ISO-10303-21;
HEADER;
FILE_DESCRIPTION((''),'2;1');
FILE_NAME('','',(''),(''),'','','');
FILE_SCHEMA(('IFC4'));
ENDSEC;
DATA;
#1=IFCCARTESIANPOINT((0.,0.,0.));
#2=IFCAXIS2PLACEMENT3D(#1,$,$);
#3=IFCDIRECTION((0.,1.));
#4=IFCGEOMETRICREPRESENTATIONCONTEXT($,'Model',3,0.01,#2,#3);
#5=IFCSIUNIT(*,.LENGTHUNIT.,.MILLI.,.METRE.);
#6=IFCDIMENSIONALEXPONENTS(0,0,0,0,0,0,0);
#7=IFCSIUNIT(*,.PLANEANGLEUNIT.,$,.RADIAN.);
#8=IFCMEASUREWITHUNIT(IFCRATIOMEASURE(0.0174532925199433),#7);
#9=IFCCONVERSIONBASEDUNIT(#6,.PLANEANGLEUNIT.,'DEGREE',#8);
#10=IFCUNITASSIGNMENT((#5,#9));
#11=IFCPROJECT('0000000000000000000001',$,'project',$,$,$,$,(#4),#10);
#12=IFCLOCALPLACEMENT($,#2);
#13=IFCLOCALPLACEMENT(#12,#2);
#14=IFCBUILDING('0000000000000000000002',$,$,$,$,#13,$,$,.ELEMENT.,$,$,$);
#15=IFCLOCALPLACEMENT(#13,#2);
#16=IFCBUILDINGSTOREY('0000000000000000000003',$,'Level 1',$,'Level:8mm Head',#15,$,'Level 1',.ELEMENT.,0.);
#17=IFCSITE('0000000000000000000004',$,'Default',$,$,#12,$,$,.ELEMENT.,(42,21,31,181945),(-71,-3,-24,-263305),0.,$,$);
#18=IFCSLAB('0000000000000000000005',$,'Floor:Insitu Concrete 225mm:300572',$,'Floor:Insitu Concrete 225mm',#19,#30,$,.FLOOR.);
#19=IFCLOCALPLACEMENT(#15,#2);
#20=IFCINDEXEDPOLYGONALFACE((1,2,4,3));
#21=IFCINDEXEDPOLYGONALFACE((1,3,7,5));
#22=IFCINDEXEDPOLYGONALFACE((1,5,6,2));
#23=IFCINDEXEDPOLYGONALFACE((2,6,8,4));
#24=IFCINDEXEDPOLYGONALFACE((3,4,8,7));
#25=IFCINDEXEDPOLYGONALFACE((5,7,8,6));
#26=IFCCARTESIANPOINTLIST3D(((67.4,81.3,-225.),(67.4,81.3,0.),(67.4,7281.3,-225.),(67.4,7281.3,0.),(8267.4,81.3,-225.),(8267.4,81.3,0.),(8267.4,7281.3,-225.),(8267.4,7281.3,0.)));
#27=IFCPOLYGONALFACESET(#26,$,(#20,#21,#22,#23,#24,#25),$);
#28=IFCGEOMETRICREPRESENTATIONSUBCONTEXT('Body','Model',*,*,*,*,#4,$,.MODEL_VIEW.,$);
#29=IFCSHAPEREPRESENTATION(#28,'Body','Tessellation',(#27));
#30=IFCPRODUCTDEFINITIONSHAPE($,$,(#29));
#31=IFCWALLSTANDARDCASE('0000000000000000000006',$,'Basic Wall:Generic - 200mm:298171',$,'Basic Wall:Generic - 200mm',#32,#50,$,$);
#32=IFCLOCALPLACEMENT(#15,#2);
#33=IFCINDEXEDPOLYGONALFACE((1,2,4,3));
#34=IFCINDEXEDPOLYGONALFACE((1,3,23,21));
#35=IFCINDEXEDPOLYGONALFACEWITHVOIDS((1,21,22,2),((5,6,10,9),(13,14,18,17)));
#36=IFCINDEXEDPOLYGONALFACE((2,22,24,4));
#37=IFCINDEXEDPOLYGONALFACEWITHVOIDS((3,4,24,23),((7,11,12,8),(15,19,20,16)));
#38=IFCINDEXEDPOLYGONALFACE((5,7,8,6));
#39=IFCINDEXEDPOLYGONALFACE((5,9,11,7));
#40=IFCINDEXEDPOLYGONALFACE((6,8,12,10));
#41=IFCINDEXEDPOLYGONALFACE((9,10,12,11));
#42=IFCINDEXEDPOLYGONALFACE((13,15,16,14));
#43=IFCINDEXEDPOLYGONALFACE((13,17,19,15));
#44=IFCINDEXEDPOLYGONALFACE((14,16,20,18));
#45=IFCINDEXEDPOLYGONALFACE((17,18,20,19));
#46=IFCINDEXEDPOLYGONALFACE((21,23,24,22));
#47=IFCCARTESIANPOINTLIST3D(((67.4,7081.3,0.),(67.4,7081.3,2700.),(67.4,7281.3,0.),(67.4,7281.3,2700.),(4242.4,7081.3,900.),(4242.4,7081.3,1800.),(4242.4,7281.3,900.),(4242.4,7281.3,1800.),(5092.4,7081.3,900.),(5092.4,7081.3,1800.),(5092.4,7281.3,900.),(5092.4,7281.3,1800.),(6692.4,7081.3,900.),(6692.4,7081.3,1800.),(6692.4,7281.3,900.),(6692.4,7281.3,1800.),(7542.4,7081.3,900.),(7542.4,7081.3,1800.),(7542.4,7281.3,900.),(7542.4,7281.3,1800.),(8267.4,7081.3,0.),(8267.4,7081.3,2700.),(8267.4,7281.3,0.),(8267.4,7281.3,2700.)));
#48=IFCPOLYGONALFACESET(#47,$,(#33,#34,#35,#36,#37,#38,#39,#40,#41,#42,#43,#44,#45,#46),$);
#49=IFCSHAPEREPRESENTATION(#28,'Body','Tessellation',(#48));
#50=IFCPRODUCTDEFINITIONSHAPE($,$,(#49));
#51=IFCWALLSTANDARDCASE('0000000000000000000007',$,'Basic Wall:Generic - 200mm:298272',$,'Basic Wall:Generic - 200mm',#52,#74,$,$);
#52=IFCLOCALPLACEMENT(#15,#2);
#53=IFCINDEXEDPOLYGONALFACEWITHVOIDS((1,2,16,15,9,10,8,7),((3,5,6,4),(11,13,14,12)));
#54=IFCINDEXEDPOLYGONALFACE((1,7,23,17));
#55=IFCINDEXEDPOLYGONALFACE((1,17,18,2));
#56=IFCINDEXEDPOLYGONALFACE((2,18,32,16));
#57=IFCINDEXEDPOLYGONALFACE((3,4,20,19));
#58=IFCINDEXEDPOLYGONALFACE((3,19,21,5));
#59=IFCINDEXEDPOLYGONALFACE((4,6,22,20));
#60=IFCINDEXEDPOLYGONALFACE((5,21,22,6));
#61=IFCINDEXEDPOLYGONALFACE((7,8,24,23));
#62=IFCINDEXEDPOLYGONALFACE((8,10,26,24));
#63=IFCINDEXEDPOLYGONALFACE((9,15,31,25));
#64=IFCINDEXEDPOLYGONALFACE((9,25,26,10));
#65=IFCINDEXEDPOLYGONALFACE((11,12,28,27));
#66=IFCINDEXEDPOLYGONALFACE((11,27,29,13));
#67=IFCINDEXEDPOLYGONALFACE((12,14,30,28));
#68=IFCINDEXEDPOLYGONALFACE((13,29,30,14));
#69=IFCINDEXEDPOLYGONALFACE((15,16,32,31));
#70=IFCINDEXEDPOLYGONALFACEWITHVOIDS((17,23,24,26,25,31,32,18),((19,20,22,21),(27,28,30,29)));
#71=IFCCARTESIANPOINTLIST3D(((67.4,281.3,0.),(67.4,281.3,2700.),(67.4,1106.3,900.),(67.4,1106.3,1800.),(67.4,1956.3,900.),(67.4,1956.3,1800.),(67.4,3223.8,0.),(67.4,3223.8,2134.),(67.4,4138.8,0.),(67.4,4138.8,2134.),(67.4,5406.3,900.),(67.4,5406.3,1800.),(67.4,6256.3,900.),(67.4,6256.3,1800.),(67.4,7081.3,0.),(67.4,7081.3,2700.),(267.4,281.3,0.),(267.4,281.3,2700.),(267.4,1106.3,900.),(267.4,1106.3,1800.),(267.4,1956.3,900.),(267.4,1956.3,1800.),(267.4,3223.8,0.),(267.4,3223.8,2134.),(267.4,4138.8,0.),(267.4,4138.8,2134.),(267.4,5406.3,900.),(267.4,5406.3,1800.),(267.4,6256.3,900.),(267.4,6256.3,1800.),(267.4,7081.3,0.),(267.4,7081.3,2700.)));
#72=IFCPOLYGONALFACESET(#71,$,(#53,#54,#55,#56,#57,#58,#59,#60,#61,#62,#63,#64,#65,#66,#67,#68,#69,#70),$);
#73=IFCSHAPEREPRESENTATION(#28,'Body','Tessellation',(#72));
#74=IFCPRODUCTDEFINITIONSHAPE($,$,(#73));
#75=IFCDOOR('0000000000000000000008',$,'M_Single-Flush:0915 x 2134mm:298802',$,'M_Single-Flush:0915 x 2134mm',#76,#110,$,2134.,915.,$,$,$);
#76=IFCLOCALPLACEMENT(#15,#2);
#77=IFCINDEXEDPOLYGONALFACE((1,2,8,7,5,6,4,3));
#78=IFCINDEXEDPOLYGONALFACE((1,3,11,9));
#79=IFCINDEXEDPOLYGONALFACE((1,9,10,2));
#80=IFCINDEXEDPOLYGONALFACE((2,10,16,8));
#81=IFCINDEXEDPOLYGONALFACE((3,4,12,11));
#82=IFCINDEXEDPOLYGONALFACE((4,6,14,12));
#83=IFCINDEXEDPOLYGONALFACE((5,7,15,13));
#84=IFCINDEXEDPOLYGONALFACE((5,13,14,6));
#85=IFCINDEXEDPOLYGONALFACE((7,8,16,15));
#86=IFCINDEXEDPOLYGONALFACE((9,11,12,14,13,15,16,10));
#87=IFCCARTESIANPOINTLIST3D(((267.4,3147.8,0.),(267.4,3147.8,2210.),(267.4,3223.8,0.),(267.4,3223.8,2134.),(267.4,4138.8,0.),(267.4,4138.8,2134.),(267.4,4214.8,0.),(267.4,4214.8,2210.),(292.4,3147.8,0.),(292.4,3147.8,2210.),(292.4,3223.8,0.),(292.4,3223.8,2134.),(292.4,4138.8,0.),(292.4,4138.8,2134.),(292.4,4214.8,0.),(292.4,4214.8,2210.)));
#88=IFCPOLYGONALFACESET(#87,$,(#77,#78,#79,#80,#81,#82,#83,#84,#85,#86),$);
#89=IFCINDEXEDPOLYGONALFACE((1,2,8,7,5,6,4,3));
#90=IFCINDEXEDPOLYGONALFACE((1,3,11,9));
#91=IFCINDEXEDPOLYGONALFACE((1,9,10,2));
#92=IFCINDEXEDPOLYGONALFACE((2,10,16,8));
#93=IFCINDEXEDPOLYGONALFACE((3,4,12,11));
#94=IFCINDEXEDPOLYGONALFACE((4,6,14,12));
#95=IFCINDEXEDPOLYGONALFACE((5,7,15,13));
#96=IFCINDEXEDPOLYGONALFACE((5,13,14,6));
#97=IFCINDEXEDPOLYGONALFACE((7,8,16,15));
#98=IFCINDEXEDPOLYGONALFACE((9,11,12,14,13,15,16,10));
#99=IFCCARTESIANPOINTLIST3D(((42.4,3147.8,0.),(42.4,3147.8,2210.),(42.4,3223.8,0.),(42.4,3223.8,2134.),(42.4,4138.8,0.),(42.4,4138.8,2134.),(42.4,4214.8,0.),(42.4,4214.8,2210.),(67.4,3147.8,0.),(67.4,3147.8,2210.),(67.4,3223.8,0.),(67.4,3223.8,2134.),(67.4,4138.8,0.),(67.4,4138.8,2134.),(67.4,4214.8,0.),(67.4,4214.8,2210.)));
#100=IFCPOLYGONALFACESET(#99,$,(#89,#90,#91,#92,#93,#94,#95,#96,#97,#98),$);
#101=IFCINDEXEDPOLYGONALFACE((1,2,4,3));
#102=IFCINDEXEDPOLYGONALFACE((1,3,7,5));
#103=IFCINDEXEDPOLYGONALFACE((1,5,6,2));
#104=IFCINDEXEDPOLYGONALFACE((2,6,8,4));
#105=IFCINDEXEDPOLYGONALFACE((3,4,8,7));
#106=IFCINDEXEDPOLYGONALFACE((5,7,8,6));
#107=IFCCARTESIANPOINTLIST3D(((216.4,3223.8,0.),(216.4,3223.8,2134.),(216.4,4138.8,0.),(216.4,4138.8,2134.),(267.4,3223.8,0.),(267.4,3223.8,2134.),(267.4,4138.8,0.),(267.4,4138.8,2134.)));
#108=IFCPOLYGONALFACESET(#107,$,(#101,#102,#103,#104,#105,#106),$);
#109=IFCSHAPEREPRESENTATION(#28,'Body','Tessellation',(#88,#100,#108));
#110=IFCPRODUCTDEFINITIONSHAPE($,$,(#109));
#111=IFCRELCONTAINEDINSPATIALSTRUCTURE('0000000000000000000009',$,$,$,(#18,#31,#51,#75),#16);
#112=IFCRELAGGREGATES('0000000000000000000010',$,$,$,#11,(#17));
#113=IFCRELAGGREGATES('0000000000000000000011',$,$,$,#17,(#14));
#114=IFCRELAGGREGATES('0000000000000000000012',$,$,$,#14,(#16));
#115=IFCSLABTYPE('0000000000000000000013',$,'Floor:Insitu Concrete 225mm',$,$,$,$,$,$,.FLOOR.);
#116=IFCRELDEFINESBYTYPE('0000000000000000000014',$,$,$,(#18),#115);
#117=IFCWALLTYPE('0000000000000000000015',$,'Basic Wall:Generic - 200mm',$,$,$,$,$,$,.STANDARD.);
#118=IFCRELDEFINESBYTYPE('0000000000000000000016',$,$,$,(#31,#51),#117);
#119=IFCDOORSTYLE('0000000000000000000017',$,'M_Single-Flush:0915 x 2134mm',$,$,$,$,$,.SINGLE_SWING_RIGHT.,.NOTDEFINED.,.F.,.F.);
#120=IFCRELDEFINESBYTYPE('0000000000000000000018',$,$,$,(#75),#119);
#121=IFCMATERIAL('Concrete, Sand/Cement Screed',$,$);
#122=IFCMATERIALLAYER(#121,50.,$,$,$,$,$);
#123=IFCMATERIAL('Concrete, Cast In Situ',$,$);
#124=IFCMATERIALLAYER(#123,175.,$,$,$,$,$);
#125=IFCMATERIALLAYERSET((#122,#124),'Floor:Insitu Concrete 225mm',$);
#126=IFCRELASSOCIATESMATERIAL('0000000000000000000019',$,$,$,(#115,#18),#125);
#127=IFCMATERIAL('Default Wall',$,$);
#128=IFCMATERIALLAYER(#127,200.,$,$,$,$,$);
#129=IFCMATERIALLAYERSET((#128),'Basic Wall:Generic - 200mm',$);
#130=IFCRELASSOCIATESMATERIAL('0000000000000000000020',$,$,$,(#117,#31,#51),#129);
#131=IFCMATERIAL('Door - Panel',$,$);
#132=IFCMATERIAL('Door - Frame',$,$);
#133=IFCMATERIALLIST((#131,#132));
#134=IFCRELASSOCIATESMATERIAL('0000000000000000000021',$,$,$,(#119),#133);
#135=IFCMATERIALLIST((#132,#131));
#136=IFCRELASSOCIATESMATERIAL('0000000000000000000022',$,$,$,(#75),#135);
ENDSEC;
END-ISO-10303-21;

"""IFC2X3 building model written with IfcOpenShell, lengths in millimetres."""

from ifc_helpers import new_model, entity, si_unit, converted_unit, direction, frame, frame_2d, origin, place, context, subcontext, project, spatial, polyline, rectangle, outline, extrude, source, transform, mapped, material, material_list, layer, layer_set, layer_usage, type_object, type_shapes, element, fill, save


model = new_model("IFC2X3")

# Units and contexts
model_context = context("Model", 3, precision=0.01, world=origin(), true_north=direction((0.0, 1.0)))
body_context = subcontext(model_context, "Body", "Model", "MODEL_VIEW")
ifc_project = project(units=[si_unit("LENGTHUNIT", "METRE", prefix="MILLI"), converted_unit("PLANEANGLEUNIT", "DEGREE", entity("IfcRatioMeasure", 0.0174532925199433), si_unit("PLANEANGLEUNIT", "RADIAN"), dimensions=[0, 0, 0, 0, 0, 0, 0])], contexts=[model_context])

# Site, building, storey
site_placement = place(None, origin())
site = spatial("IfcSite", under=ifc_project, at=site_placement, Name="Default", CompositionType="ELEMENT", RefLatitude=(42, 21, 31, 181945), RefLongitude=(-71, -3, -24, -263305), RefElevation=0.0)
building_placement = place(site_placement, origin())
building = spatial("IfcBuilding", under=site, at=building_placement, CompositionType="ELEMENT")
storey_placement = place(building_placement, origin())
storey = spatial("IfcBuildingStorey", under=building, at=storey_placement, Name="Level 1", ObjectType="Level:8mm Head", LongName="Level 1", CompositionType="ELEMENT", Elevation=0.0)

# Slab
ifc_material_1 = material(Name="Concrete, Sand/Cement Screed")
ifc_layer_1 = layer(ifc_material_1, 50.0)
ifc_material_2 = material(Name="Concrete, Cast In Situ")
ifc_layer_2 = layer(ifc_material_2, 175.0)
ifc_layer_set_1 = layer_set([ifc_layer_1, ifc_layer_2], Name="Floor:Insitu Concrete 225mm")
ifc_layer_usage_1 = layer_usage(ifc_layer_set_1, "AXIS3", "POSITIVE", 0.0)
slab_type = type_object("IfcSlabType", Name="Floor:Insitu Concrete 225mm", PredefinedType="FLOOR", material=ifc_layer_set_1)
slab_placement = place(storey_placement, origin())
element("IfcSlab", 1, at=slab_placement, inside=storey, type_object=slab_type, material=ifc_layer_usage_1, Name="Floor:Insitu Concrete 225mm:300572", ObjectType="Floor:Insitu Concrete 225mm", PredefinedType="FLOOR", context=body_context, shape_type="SweptSolid", body=[
    extrude(rectangle(XDim=7200.0, YDim=8200.0, at=frame_2d((0.0, 0.0), x_axis=(1.0, 0.0))), frame((4167.4, 3681.3, 0.0), z_axis=(0.0, 0.0, -1.0), x_axis=(0.0, 1.0, 0.0)), (0.0, 0.0, 1.0), 225.0),
])

# Wall, openings
ifc_material_3 = material(Name="Default Wall")
ifc_layer_3 = layer(ifc_material_3, 200.0)
ifc_layer_set_2 = layer_set([ifc_layer_3], Name="Basic Wall:Generic - 200mm")
ifc_layer_usage_2 = layer_usage(ifc_layer_set_2, "AXIS2", "NEGATIVE", 100.0)
wall_type = type_object("IfcWallType", Name="Basic Wall:Generic - 200mm", PredefinedType="STANDARD", material=ifc_layer_set_2)
wall_1_placement = place(storey_placement, frame((67.4, 7181.3, 0.0)))
wall_1 = element("IfcWallStandardCase", 2, at=wall_1_placement, inside=storey, type_object=wall_type, material=ifc_layer_usage_2, Name="Basic Wall:Generic - 200mm:298171", ObjectType="Basic Wall:Generic - 200mm", context=body_context, shape_type="SweptSolid", body=[
    extrude(rectangle(XDim=8200.0, YDim=200.0, at=frame_2d((4100.0, 0.0), x_axis=(-1.0, 0.0))), origin(), (0.0, 0.0, 1.0), 2700.0),
])
opening_1_placement = place(wall_1_placement, frame((5025.0, 100.0, 900.0)))
element("IfcOpeningElement", 3, at=opening_1_placement, cuts=wall_1, ObjectType="Opening", context=body_context, shape_type="SweptSolid", body=[
    extrude(rectangle(XDim=900.0, YDim=850.0, at=frame_2d((450.0, 425.0), x_axis=(-1.0, 0.0))), frame((0.0, 0.0, 0.0), z_axis=(0.0, -1.0, 0.0), x_axis=(0.0, 0.0, 1.0)), (0.0, 0.0, 1.0), 200.0),
])
opening_2_placement = place(wall_1_placement, frame((7475.0, 100.0, 900.0)))
element("IfcOpeningElement", 4, at=opening_2_placement, cuts=wall_1, ObjectType="Opening", context=body_context, shape_type="SweptSolid", body=[
    extrude(rectangle(XDim=900.0, YDim=850.0, at=frame_2d((450.0, 425.0), x_axis=(-1.0, 0.0))), frame((0.0, 0.0, 0.0), z_axis=(0.0, -1.0, 0.0), x_axis=(0.0, 0.0, 1.0)), (0.0, 0.0, 1.0), 200.0),
])

# Wall, openings, door
ifc_layer_usage_3 = layer_usage(ifc_layer_set_2, "AXIS2", "NEGATIVE", 100.0)
wall_2_placement = place(storey_placement, frame((167.4, 281.3, 0.0), z_axis=(0.0, 0.0, 1.0), x_axis=(0.0, 1.0, 0.0)))
wall_2 = element("IfcWallStandardCase", 5, at=wall_2_placement, inside=storey, type_object=wall_type, material=ifc_layer_usage_3, Name="Basic Wall:Generic - 200mm:298272", ObjectType="Basic Wall:Generic - 200mm", context=body_context, shape_type="SweptSolid", body=[
    extrude(rectangle(XDim=6800.0, YDim=200.0, at=frame_2d((3400.0, 0.0), x_axis=(-1.0, 0.0))), origin(), (0.0, 0.0, 1.0), 2700.0),
])
opening_3_placement = place(wall_2_placement, frame((3857.5, 100.0, 0.0)))
opening_3 = element("IfcOpeningElement", 6, at=opening_3_placement, cuts=wall_2, ObjectType="Opening", context=body_context, shape_type="SweptSolid", body=[
    extrude(rectangle(XDim=915.0, YDim=2134.0, at=frame_2d((1067.0, 457.5), x_axis=(0.0, 1.0))), frame((0.0, 0.0, 0.0), z_axis=(0.0, -1.0, 0.0), x_axis=(0.0, 0.0, 1.0)), (0.0, 0.0, 1.0), 200.0),
])
opening_4_placement = place(wall_2_placement, frame((5975.0, 100.0, 900.0)))
element("IfcOpeningElement", 7, at=opening_4_placement, cuts=wall_2, ObjectType="Opening", context=body_context, shape_type="SweptSolid", body=[
    extrude(rectangle(XDim=900.0, YDim=850.0, at=frame_2d((450.0, 425.0), x_axis=(-1.0, 0.0))), frame((0.0, 0.0, 0.0), z_axis=(0.0, -1.0, 0.0), x_axis=(0.0, 0.0, 1.0)), (0.0, 0.0, 1.0), 200.0),
])
opening_5_placement = place(wall_2_placement, frame((1675.0, 100.0, 900.0)))
element("IfcOpeningElement", 8, at=opening_5_placement, cuts=wall_2, ObjectType="Opening", context=body_context, shape_type="SweptSolid", body=[
    extrude(rectangle(XDim=900.0, YDim=850.0, at=frame_2d((450.0, 425.0), x_axis=(-1.0, 0.0))), frame((0.0, 0.0, 0.0), z_axis=(0.0, -1.0, 0.0), x_axis=(0.0, 0.0, 1.0)), (0.0, 0.0, 1.0), 200.0),
])
ifc_material_4 = material(Name="Door - Frame")
ifc_material_5 = material(Name="Door - Panel")
ifc_material_list_1 = material_list([ifc_material_4, ifc_material_5])
ifc_material_list_2 = material_list([ifc_material_5, ifc_material_4])
door_style = type_object("IfcDoorStyle", Name="M_Single-Flush:0915 x 2134mm", ConstructionType="NOTDEFINED", OperationType="SINGLE_SWING_RIGHT", ParameterTakesPrecedence=False, Sizeable=False, material=ifc_material_list_2)
shared_shape_1 = source(origin(), body_context, "Body", "SweptSolid", [
    extrude(outline(polyline([(-533.5, -1124.0), (533.5, -1124.0), (533.5, 1086.0), (457.5, 1086.0), (457.5, -1048.0), (-457.5, -1048.0), (-457.5, 1086.0), (-533.5, 1086.0), (-533.5, -1124.0)])), frame((457.5, 200.0, 1086.0), z_axis=(0.0, 1.0, 0.0), x_axis=(1.0, 0.0, 0.0)), (0.0, 0.0, 1.0), 25.0),
    extrude(outline(polyline([(-1124.0, -533.5), (1086.0, -533.5), (1086.0, -457.5), (-1048.0, -457.5), (-1048.0, 457.5), (1086.0, 457.5), (1086.0, 533.5), (-1124.0, 533.5), (-1124.0, -533.5)])), frame((457.5, -25.0, 1086.0), z_axis=(0.0, 1.0, 0.0), x_axis=(0.0, 0.0, -1.0)), (0.0, 0.0, 1.0), 25.0),
    extrude(rectangle(XDim=51.0, YDim=915.0, at=frame_2d((0.0, 0.0), x_axis=(1.0, 0.0))), frame((457.5, 174.5, 0.0), z_axis=(0.0, 0.0, 1.0), x_axis=(0.0, 1.0, 0.0)), (0.0, 0.0, 1.0), 2134.0),
])
type_shapes(door_style, [shared_shape_1])
door_1_placement = place(opening_3_placement, frame((0.0, 0.0, 0.0), z_axis=(0.0, 0.0, 1.0), x_axis=(-1.0, 0.0, 0.0)))
door_1 = element("IfcDoor", 9, at=door_1_placement, inside=storey, type_object=door_style, material=ifc_material_list_1, Name="M_Single-Flush:0915 x 2134mm:298802", ObjectType="M_Single-Flush:0915 x 2134mm", OverallHeight=2134.0, OverallWidth=915.0, context=body_context, shape_type="MappedRepresentation", body=[
    mapped(shared_shape_1, transform((0.0, 0.0, 0.0), scale=1.0)),
])
fill(opening_3, door_1)

save(model, "model.ifc")
